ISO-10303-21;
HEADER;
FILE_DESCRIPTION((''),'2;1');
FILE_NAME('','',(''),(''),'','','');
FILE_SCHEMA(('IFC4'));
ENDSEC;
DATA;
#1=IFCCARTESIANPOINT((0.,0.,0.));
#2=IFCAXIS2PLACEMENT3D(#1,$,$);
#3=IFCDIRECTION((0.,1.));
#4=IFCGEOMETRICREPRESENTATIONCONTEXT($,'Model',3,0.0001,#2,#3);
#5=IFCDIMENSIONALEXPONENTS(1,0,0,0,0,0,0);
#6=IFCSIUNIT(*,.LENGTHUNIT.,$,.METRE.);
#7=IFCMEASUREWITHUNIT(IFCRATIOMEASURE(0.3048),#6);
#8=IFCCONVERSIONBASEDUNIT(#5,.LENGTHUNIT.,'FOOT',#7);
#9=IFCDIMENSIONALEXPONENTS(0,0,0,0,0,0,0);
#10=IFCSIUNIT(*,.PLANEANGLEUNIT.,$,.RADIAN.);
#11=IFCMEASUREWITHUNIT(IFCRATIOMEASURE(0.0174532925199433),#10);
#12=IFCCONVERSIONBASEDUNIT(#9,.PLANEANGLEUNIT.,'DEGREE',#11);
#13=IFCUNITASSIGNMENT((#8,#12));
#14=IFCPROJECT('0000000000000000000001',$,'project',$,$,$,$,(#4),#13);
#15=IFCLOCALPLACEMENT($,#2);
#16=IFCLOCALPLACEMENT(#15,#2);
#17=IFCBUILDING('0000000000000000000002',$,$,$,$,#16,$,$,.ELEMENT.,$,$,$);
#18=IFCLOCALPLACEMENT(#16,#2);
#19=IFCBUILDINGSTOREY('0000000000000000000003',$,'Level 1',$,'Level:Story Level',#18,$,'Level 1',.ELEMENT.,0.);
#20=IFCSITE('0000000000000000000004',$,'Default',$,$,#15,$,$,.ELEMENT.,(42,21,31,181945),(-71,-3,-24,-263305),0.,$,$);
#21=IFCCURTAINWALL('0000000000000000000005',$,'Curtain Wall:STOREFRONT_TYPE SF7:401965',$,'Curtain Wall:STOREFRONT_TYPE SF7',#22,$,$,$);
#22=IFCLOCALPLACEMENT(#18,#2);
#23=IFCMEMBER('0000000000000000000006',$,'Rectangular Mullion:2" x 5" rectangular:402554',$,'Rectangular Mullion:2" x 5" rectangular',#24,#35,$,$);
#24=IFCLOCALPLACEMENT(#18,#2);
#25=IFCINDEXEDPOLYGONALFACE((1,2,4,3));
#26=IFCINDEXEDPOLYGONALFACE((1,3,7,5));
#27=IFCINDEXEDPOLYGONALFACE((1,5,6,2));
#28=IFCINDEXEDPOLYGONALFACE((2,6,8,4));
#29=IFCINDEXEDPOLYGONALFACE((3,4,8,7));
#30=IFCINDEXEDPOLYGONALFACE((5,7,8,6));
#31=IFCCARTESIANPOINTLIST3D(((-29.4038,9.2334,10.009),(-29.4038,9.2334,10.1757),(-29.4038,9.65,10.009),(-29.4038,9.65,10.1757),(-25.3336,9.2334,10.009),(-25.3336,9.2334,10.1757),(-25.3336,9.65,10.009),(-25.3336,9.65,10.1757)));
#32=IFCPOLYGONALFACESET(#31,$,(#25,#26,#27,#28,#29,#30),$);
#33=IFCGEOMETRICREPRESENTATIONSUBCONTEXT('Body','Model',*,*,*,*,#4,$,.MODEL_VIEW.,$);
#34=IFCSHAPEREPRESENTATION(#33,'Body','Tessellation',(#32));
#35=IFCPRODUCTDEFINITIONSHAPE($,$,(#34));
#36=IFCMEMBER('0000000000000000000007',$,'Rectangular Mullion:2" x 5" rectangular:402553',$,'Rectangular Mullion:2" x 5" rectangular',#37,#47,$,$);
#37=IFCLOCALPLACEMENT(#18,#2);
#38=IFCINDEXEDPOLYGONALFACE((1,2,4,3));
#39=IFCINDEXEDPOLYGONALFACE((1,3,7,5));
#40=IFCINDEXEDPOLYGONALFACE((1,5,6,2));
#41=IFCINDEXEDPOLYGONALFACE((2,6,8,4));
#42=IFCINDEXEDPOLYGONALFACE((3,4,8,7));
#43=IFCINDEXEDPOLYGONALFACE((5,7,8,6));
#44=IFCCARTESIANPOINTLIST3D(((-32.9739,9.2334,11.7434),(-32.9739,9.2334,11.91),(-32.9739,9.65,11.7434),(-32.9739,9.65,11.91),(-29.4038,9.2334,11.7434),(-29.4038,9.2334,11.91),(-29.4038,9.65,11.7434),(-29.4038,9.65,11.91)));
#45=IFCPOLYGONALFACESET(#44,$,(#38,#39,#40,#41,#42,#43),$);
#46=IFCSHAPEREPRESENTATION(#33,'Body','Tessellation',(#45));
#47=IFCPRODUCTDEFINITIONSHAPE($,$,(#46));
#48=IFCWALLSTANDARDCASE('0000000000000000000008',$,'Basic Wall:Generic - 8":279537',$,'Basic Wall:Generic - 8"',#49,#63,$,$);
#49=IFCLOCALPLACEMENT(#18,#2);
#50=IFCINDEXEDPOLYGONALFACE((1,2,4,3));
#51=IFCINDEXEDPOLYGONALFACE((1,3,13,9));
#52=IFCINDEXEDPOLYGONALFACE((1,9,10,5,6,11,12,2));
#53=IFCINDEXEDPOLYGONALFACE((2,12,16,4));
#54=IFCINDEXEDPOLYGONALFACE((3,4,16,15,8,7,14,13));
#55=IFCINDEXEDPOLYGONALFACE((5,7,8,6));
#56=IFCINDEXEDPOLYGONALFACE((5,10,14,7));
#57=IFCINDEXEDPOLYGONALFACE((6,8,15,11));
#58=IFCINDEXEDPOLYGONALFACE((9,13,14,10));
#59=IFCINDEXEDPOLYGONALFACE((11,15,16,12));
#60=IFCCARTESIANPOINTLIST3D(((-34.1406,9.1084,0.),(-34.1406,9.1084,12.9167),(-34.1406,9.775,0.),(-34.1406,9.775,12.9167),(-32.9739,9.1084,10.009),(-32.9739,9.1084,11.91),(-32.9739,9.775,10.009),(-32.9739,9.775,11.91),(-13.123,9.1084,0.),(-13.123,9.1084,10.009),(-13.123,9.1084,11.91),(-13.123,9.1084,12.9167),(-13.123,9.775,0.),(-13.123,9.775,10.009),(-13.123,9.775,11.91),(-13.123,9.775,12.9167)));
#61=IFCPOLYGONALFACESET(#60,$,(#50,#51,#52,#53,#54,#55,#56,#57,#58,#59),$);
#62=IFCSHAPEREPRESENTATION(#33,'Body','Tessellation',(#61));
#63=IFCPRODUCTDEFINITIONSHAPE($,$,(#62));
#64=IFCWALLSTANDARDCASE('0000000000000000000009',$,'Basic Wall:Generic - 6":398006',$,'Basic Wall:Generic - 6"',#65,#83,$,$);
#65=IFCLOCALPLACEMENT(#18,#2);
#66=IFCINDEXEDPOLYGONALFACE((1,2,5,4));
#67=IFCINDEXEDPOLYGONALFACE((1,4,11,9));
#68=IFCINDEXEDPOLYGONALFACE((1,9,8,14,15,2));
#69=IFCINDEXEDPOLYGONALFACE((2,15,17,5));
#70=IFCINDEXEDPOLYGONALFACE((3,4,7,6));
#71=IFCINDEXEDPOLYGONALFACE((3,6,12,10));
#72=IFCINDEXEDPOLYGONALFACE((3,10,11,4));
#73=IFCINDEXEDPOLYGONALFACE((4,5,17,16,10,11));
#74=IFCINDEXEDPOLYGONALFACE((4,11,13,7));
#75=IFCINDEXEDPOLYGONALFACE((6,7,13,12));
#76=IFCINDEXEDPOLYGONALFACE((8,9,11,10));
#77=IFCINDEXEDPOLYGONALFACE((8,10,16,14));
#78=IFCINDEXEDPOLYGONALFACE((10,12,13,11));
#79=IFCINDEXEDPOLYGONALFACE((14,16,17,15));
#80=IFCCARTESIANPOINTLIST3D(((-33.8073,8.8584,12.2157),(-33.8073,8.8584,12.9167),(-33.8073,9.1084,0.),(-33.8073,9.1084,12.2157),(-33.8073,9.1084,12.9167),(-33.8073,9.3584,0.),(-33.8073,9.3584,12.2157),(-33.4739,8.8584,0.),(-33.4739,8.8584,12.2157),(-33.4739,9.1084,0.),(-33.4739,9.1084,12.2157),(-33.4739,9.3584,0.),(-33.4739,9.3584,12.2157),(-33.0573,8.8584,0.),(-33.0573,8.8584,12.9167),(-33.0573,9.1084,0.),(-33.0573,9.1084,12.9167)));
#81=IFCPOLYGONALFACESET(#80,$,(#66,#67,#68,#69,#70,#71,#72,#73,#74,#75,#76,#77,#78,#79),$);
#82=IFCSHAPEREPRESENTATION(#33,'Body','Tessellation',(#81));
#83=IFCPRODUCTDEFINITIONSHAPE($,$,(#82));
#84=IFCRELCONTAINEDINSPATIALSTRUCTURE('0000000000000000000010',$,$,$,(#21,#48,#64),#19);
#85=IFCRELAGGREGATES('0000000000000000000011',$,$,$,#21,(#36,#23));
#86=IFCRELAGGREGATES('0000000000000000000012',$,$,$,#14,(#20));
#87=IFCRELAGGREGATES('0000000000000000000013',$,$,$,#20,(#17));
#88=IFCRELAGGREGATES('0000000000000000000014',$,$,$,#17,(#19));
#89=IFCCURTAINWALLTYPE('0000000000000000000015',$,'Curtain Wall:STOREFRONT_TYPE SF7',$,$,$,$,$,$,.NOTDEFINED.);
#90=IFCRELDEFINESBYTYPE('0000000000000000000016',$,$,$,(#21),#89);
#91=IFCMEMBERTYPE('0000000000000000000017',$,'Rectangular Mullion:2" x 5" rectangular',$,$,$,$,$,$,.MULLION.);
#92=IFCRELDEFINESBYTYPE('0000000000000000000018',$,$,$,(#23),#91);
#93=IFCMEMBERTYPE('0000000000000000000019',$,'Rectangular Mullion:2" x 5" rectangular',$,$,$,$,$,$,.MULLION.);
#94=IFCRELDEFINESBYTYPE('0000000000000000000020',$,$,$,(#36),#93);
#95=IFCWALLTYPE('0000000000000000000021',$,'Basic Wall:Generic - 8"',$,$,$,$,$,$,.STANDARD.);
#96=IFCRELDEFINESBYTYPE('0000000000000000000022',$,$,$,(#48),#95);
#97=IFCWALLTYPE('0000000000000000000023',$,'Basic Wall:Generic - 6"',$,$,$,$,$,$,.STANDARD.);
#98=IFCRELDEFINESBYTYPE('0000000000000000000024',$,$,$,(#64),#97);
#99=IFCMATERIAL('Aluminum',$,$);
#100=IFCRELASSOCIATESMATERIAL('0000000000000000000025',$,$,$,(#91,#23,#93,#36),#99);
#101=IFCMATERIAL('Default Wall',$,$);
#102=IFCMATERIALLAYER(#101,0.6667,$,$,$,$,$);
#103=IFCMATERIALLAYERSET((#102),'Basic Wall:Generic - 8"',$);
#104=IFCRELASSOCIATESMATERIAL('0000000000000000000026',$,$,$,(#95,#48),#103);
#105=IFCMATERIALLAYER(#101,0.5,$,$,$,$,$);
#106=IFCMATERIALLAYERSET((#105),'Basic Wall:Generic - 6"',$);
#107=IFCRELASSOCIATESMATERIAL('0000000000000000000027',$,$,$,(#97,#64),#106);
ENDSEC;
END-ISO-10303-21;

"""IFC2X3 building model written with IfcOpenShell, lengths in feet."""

from ifc_helpers import new_model, entity, si_unit, converted_unit, direction, frame, frame_2d, origin, origin_2d_with_axis, place, context, subcontext, project, spatial, polyline, rectangle, extrude, clip, bounded_halfspace, source, transform, mapped, material, layer, layer_set, layer_usage, type_object, type_shapes, element, aggregate, save


model = new_model("IFC2X3")

# Units and contexts
model_context = context("Model", 3, precision=0.0001, world=origin(), true_north=direction((0.0, 1.0)))
body_context = subcontext(model_context, "Body", "Model", "MODEL_VIEW")
ifc_project = project(units=[converted_unit("LENGTHUNIT", "FOOT", entity("IfcRatioMeasure", 0.3048), si_unit("LENGTHUNIT", "METRE"), dimensions=[1, 0, 0, 0, 0, 0, 0]), converted_unit("PLANEANGLEUNIT", "DEGREE", entity("IfcRatioMeasure", 0.0174532925199433), si_unit("PLANEANGLEUNIT", "RADIAN"), dimensions=[0, 0, 0, 0, 0, 0, 0])], contexts=[model_context])

# Site, building, storey
site_placement = place(None, origin())
site = spatial("IfcSite", under=ifc_project, at=site_placement, Name="Default", CompositionType="ELEMENT", RefLatitude=(42, 21, 31, 181945), RefLongitude=(-71, -3, -24, -263305), RefElevation=0.0)
building_placement = place(site_placement, origin())
building = spatial("IfcBuilding", under=site, at=building_placement, CompositionType="ELEMENT")
storey_placement = place(building_placement, origin())
storey = spatial("IfcBuildingStorey", under=building, at=storey_placement, Name="Level 1", ObjectType="Level:Story Level", LongName="Level 1", CompositionType="ELEMENT", Elevation=0.0)

# Curtain wall, members
curtain_wall_type = type_object("IfcCurtainWallType", Name="Curtain Wall:STOREFRONT_TYPE SF7", PredefinedType="NOTDEFINED")
curtain_wall_placement = place(storey_placement, origin())
curtain_wall = element("IfcCurtainWall", 1, at=curtain_wall_placement, inside=storey, type_object=curtain_wall_type, Name="Curtain Wall:STOREFRONT_TYPE SF7:401965", ObjectType="Curtain Wall:STOREFRONT_TYPE SF7")
ifc_material_1 = material(Name="Aluminum")
member_type_1 = type_object("IfcMemberType", Name="Rectangular Mullion:2\" x 5\" rectangular", PredefinedType="MULLION", material=ifc_material_1)
shared_shape_1 = source(origin(), body_context, "Body", "SweptSolid", [
    extrude(rectangle(XDim=0.4167, YDim=0.1667, at=origin_2d_with_axis()), frame((-0.0833, 0.0, -4.0702), z_axis=(0.0, 0.0, 1.0), x_axis=(0.0, -1.0, 0.0)), (0.0, 0.0, 1.0), 4.0702),
])
type_shapes(member_type_1, [shared_shape_1])
member_1_placement = place(curtain_wall_placement, frame((-29.4038, 9.4417, 10.009), z_axis=(-1.0, 0.0, 0.0), x_axis=(0.0, 0.0, -1.0)))
member_1 = element("IfcMember", 2, at=member_1_placement, type_object=member_type_1, material=ifc_material_1, Name="Rectangular Mullion:2\" x 5\" rectangular:402554", ObjectType="Rectangular Mullion:2\" x 5\" rectangular", context=body_context, shape_type="MappedRepresentation", body=[
    mapped(shared_shape_1, transform((0.0, 0.0, 0.0), scale=1.0)),
])
member_type_2 = type_object("IfcMemberType", Name="Rectangular Mullion:2\" x 5\" rectangular", PredefinedType="MULLION", material=ifc_material_1)
shared_shape_2 = source(origin(), body_context, "Body", "SweptSolid", [
    extrude(rectangle(XDim=0.4167, YDim=0.1667, at=origin_2d_with_axis()), frame((-0.0833, 0.0, -3.5702), z_axis=(0.0, 0.0, 1.0), x_axis=(0.0, -1.0, 0.0)), (0.0, 0.0, 1.0), 3.5702),
])
type_shapes(member_type_2, [shared_shape_2])
member_2_placement = place(curtain_wall_placement, frame((-29.4038, 9.4417, 11.91), z_axis=(1.0, 0.0, 0.0), x_axis=(0.0, 0.0, 1.0)))
member_2 = element("IfcMember", 3, at=member_2_placement, type_object=member_type_2, material=ifc_material_1, Name="Rectangular Mullion:2\" x 5\" rectangular:402553", ObjectType="Rectangular Mullion:2\" x 5\" rectangular", context=body_context, shape_type="MappedRepresentation", body=[
    mapped(shared_shape_2, transform((0.0, 0.0, 0.0), scale=1.0)),
])
aggregate(curtain_wall, [member_2, member_1])

# Walls, openings
ifc_material_2 = material(Name="Default Wall")
ifc_layer_1 = layer(ifc_material_2, 0.6667)
ifc_layer_set_1 = layer_set([ifc_layer_1], Name="Basic Wall:Generic - 8\"")
ifc_layer_usage_1 = layer_usage(ifc_layer_set_1, "AXIS2", "NEGATIVE", 0.3333)
wall_type_1 = type_object("IfcWallType", Name="Basic Wall:Generic - 8\"", PredefinedType="STANDARD", material=ifc_layer_set_1)
wall_1_placement = place(storey_placement, frame((-34.1406, 9.4417, 0.0)))
wall_1 = element("IfcWallStandardCase", 4, at=wall_1_placement, inside=storey, type_object=wall_type_1, material=ifc_layer_usage_1, Name="Basic Wall:Generic - 8\":279537", ObjectType="Basic Wall:Generic - 8\"", context=body_context, shape_type="SweptSolid", body=[
    extrude(rectangle(XDim=21.0176, YDim=0.6667, at=frame_2d((10.5088, 0.0), x_axis=(-1.0, 0.0))), origin(), (0.0, 0.0, 1.0), 12.9167),
])
opening_1_placement = place(wall_1_placement, origin())
element("IfcOpeningElement", 5, at=opening_1_placement, cuts=wall_1, ObjectType="Opening", context=body_context, shape_type="SweptSolid", body=[
    extrude(rectangle(XDim=1.901, YDim=19.8509, at=origin_2d_with_axis()), frame((11.0921, -0.8333, 10.9595), z_axis=(0.0, 1.0, 0.0), x_axis=(0.0, 0.0, 1.0)), (0.0, 0.0, 1.0), 1.6667),
])
ifc_layer_2 = layer(ifc_material_2, 0.5)
ifc_layer_set_2 = layer_set([ifc_layer_2], Name="Basic Wall:Generic - 6\"")
ifc_layer_usage_2 = layer_usage(ifc_layer_set_2, "AXIS2", "NEGATIVE", 0.25)
wall_type_2 = type_object("IfcWallType", Name="Basic Wall:Generic - 6\"", PredefinedType="STANDARD", material=ifc_layer_set_2)
wall_2_placement = place(storey_placement, frame((-33.8073, 9.1084, 0.0)))
wall_2 = element("IfcWallStandardCase", 6, at=wall_2_placement, inside=storey, type_object=wall_type_2, material=ifc_layer_usage_2, Name="Basic Wall:Generic - 6\":398006", ObjectType="Basic Wall:Generic - 6\"", context=body_context, shape_type="Clipping", body=[
    clip(clip(clip(extrude(rectangle(XDim=0.75, YDim=0.5, at=frame_2d((0.375, 0.0), x_axis=(-1.0, 0.0))), origin(), (0.0, 0.0, 1.0), 12.9167), bounded_halfspace(frame((0.75, 0.0, 12.9167), z_axis=(0.0, -1.0, 0.0), x_axis=(1.0, 0.0, 0.0)), True, frame((0.75, 0.0, 12.9167), z_axis=(0.0, -1.0, 0.0), x_axis=(1.0, 0.0, 0.0)), polyline([(0.0, 0.0), (-0.75, 0.0), (-0.75, -0.701), (-0.4167, -0.701), (-0.4167, -12.9167), (0.0, -12.9167), (0.0, 0.0)]))), bounded_halfspace(frame((0.3333, -0.25, 12.2157), z_axis=(1.0, 0.0, 0.0), x_axis=(0.0, 1.0, 0.0)), True, frame((0.3333, -0.25, 12.2157), z_axis=(1.0, 0.0, 0.0), x_axis=(0.0, 1.0, 0.0)), polyline([(0.0, 0.0), (0.0, -12.2157), (0.25, -12.2157), (0.25, 0.0), (0.0, 0.0)]))), bounded_halfspace(frame((0.3333, 0.0, 12.2157), z_axis=(0.0, 0.0, 1.0), x_axis=(-1.0, 0.0, 0.0)), True, frame((0.3333, 0.0, 12.2157), z_axis=(0.0, 0.0, 1.0), x_axis=(-1.0, 0.0, 0.0)), polyline([(0.0, 0.0), (0.3333, 0.0), (0.3333, 0.25), (0.0, 0.25), (0.0, 0.0)]))),
])
opening_2_placement = place(wall_2_placement, origin())
element("IfcOpeningElement", 7, at=opening_2_placement, cuts=wall_2, ObjectType="Opening", context=body_context, shape_type="SweptSolid", body=[
    extrude(rectangle(XDim=1.901, YDim=19.8509, at=frame_2d((0.0, 0.0), x_axis=(1.0, 0.0))), frame((10.7588, -0.75, 10.9595), z_axis=(0.0, 1.0, 0.0), x_axis=(0.0, 0.0, 1.0)), (0.0, 0.0, 1.0), 1.5),
])

save(model, "model.ifc")
